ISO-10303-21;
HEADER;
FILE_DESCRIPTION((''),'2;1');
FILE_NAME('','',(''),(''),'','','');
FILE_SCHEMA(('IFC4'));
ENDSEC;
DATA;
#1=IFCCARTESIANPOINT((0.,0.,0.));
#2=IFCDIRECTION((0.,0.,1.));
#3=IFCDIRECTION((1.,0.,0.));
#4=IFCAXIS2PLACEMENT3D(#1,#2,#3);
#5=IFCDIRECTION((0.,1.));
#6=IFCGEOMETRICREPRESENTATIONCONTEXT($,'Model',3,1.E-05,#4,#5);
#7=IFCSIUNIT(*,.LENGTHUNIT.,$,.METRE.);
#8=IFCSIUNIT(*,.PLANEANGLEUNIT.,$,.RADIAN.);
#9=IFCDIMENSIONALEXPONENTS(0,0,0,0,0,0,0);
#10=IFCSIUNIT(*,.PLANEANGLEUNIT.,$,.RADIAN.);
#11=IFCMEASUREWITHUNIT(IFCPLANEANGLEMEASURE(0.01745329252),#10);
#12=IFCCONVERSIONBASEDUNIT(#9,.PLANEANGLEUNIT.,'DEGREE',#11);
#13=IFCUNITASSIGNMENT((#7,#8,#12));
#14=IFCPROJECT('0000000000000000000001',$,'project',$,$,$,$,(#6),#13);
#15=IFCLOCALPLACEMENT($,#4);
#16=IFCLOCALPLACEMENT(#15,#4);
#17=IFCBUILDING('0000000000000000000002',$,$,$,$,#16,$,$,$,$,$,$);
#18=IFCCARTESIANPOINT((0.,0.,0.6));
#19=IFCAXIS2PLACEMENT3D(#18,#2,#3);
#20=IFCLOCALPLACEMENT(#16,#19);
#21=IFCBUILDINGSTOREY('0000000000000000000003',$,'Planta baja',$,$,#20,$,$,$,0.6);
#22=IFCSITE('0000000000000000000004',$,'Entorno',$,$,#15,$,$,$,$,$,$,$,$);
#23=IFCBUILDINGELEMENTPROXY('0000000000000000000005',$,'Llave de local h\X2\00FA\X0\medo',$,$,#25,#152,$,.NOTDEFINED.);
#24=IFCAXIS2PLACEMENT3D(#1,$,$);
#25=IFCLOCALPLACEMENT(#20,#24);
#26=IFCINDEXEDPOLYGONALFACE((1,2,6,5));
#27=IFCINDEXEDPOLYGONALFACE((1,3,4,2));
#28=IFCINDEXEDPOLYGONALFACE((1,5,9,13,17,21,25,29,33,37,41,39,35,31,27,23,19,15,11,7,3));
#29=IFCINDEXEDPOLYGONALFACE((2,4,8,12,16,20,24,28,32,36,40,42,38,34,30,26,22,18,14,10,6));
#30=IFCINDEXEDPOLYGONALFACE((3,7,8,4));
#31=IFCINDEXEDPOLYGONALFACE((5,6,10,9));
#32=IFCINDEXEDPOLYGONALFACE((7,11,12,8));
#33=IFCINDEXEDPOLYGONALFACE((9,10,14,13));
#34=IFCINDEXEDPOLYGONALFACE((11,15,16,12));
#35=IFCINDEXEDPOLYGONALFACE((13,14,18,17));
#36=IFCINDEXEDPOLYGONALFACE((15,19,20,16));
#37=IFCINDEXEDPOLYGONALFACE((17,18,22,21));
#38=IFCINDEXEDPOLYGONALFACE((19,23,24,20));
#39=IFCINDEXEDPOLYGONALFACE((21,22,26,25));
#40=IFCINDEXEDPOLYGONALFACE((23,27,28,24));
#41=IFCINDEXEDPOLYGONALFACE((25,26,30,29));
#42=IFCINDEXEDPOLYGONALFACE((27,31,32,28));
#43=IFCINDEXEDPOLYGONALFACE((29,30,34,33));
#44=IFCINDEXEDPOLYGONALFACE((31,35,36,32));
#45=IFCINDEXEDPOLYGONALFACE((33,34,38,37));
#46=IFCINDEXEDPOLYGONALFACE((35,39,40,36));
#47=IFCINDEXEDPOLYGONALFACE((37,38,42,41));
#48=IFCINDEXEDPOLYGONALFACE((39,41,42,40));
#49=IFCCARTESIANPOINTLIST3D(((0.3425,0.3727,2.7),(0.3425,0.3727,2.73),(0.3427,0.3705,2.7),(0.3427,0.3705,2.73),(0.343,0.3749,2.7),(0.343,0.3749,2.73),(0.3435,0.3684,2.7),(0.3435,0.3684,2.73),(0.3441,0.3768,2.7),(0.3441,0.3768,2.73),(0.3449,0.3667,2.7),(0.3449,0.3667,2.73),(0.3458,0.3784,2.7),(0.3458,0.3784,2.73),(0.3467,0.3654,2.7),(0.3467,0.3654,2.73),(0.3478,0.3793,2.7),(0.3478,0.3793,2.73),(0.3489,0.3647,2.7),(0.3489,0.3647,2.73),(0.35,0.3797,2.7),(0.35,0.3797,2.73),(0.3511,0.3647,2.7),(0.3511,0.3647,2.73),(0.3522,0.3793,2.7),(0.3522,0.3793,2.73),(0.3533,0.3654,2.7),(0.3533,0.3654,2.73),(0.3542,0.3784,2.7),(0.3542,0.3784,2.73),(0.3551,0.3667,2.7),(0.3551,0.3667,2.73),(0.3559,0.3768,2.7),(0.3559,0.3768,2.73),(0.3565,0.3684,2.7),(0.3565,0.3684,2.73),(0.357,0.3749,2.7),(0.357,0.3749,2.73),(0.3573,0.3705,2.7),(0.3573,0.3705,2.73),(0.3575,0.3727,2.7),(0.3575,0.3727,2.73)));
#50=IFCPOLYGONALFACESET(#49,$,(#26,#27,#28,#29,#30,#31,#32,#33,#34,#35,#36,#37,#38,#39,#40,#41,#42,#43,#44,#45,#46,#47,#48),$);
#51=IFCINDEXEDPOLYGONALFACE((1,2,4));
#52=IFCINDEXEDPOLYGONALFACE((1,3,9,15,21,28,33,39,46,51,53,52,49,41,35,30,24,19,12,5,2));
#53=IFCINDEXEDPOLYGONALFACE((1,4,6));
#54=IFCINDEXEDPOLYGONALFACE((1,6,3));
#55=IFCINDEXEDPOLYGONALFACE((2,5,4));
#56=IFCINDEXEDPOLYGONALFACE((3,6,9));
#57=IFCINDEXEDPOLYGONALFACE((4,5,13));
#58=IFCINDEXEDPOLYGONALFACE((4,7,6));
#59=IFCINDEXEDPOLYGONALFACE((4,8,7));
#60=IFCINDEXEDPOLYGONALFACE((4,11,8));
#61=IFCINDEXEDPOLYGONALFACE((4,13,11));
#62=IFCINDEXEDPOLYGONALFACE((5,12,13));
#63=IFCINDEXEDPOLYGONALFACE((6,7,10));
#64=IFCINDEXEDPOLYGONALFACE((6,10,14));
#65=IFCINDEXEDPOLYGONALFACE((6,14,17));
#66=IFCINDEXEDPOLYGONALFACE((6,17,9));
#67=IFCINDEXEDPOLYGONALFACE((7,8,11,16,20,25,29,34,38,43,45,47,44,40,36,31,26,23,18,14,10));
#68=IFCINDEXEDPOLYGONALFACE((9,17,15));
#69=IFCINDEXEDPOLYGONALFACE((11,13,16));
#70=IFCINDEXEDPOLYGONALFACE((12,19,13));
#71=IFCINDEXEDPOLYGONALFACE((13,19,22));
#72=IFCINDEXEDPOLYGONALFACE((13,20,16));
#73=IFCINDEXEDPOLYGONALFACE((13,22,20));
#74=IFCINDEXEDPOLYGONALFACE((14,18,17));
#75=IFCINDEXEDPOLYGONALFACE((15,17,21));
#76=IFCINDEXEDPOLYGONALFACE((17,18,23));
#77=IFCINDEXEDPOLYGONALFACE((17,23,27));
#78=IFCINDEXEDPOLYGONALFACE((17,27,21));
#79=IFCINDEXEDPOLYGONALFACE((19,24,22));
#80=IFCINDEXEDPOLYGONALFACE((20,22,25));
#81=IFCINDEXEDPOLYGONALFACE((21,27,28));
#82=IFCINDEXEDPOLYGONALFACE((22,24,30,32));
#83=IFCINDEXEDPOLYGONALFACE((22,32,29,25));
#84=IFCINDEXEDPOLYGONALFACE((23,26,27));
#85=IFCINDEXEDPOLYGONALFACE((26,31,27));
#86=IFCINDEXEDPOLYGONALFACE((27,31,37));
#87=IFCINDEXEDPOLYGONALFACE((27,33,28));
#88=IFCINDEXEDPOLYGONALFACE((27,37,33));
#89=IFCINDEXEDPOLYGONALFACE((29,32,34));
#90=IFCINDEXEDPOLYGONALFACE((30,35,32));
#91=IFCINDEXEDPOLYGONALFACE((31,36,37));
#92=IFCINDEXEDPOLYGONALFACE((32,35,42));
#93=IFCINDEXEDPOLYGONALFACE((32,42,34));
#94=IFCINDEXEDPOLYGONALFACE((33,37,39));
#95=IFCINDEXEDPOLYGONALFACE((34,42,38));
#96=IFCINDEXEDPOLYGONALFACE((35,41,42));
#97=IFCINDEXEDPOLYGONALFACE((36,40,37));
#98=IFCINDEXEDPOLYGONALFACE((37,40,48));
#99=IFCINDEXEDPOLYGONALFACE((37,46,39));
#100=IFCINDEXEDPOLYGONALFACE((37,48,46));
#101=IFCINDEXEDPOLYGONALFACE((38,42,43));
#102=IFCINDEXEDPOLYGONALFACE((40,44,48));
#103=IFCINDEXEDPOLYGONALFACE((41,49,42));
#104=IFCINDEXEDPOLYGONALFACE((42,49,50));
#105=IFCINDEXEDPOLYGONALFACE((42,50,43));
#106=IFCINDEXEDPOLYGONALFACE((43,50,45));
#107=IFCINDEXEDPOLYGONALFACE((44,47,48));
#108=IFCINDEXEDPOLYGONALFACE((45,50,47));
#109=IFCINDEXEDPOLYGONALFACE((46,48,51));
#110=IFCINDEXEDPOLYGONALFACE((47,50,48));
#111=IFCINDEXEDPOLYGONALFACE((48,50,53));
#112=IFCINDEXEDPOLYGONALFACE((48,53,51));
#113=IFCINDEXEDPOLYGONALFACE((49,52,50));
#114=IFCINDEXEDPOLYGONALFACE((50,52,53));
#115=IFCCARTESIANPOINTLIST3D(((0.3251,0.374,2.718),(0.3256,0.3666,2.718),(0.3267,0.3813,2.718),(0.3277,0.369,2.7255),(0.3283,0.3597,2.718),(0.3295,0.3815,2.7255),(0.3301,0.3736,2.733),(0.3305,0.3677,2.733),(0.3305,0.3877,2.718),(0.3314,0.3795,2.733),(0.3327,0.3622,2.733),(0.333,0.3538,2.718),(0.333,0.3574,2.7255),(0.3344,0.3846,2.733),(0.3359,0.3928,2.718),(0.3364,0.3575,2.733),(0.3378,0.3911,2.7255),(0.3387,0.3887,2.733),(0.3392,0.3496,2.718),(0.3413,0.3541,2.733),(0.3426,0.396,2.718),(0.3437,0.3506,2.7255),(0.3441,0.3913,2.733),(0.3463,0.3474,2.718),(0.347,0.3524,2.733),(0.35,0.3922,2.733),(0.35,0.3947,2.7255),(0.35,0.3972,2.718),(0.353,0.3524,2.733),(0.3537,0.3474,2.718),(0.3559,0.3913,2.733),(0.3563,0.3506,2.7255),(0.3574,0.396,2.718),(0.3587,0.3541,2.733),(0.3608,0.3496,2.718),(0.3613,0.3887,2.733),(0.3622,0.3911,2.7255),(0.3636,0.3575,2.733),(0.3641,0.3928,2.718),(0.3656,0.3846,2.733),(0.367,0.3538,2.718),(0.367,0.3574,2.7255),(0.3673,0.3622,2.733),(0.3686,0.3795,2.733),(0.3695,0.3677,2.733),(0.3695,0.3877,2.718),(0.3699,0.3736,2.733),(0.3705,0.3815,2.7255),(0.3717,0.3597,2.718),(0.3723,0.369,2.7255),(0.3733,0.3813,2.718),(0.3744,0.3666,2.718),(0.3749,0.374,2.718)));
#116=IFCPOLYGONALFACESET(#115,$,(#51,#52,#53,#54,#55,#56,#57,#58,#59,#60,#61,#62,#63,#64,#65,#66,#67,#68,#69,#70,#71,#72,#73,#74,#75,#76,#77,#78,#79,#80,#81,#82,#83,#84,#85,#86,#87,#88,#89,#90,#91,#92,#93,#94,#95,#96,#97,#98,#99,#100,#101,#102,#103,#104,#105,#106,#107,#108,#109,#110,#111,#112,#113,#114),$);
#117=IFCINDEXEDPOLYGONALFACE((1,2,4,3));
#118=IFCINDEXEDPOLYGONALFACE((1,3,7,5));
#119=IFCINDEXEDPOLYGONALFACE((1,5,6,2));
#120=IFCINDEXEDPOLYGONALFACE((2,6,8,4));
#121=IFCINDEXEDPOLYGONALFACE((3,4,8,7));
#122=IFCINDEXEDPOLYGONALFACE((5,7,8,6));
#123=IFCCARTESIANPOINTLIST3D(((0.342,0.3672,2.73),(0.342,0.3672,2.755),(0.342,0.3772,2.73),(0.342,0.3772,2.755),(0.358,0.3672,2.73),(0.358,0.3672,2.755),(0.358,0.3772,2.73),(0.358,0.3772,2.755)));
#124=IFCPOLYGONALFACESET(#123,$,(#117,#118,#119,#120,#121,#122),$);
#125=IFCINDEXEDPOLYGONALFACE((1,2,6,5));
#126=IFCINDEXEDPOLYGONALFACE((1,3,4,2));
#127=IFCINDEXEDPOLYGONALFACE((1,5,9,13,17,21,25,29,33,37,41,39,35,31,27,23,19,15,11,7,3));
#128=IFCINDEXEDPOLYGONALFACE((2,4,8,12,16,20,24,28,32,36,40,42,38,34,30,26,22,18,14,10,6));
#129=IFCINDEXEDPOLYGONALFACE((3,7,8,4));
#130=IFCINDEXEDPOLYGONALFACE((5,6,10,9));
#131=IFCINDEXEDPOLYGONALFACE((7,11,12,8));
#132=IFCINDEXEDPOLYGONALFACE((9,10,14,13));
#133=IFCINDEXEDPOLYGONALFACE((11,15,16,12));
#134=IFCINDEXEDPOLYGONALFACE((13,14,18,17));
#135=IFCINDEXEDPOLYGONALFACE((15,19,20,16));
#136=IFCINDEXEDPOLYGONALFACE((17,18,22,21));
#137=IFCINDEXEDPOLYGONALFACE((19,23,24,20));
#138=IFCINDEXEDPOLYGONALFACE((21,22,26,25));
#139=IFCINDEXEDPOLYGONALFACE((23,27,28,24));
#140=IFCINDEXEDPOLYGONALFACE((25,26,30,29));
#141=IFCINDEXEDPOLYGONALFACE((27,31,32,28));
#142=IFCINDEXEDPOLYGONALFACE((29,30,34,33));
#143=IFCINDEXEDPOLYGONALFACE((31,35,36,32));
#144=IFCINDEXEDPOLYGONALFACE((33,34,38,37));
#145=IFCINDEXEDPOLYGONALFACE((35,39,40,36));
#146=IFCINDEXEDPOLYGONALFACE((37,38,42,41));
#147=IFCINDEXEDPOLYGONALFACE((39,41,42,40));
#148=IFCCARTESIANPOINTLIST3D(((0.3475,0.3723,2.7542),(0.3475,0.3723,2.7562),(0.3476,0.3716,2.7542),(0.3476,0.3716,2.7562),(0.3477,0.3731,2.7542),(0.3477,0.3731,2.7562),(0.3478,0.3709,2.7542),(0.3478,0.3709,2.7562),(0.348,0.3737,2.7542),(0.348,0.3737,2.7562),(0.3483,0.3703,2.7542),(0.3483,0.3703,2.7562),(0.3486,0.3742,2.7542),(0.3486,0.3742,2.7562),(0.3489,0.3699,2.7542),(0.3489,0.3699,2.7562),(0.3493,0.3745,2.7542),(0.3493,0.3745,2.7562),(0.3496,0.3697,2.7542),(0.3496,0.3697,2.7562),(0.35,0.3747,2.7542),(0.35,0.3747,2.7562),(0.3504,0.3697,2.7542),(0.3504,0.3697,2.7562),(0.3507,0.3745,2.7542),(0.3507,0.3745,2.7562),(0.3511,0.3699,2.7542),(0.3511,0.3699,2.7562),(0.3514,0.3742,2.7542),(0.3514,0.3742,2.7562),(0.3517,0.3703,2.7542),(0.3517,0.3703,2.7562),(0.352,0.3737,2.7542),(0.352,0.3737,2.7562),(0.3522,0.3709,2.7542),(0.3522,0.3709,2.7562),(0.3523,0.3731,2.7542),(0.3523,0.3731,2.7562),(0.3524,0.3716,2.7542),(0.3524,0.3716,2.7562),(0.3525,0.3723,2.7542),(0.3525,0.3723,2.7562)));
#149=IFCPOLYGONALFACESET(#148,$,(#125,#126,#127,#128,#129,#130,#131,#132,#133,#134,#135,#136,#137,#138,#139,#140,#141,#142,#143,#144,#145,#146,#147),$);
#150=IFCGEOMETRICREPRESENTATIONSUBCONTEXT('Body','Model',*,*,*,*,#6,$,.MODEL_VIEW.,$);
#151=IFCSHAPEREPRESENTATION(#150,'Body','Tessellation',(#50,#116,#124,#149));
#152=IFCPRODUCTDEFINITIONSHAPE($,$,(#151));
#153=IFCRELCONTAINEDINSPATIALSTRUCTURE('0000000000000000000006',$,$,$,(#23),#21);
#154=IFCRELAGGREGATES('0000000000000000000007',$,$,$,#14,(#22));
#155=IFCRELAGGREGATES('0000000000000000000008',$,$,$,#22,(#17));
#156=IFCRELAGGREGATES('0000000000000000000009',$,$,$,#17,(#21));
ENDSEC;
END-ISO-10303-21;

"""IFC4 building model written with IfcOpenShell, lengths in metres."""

from ifc_helpers import new_model, entity, si_unit, converted_unit, direction, frame, origin_with_axes, place, context, subcontext, project, spatial, polyline, outline, extrude, element, save


model = new_model("IFC4")

# Units and contexts
model_context = context("Model", 3, precision=1e-05, world=origin_with_axes(), true_north=direction((0.0, 1.0)))
body_context = subcontext(model_context, "Body", "Model", "MODEL_VIEW")
ifc_project = project(units=[si_unit("LENGTHUNIT", "METRE"), si_unit("PLANEANGLEUNIT", "RADIAN"), converted_unit("PLANEANGLEUNIT", "DEGREE", entity("IfcPlaneAngleMeasure", 0.01745329252), si_unit("PLANEANGLEUNIT", "RADIAN"), dimensions=[0, 0, 0, 0, 0, 0, 0])], contexts=[model_context])

# Site, building, storey
site_placement = place(None, origin_with_axes())
site = spatial("IfcSite", under=ifc_project, at=site_placement, Name="Entorno")
building_placement = place(site_placement, origin_with_axes())
building = spatial("IfcBuilding", under=site, at=building_placement)
storey_placement = place(building_placement, frame((0.0, 0.0, 0.6), z_axis=(0.0, 0.0, 1.0), x_axis=(1.0, 0.0, 0.0)))
storey = spatial("IfcBuildingStorey", under=building, at=storey_placement, Name="Planta baja", Elevation=0.6)

# Building element proxy
proxy_1_placement = place(storey_placement, frame((0.0, 0.0, -0.6), z_axis=(0.0, 0.0, 1.0), x_axis=(1.0, 0.0, 0.0)))
ifc_direction_1 = entity("IfcDirection", [0.0, 0.0, 1.0])
ifc_direction_2 = entity("IfcDirection", [0.0, 0.0, 1.0])
ifc_direction_3 = entity("IfcDirection", [0.0, 0.0, 1.0])
element("IfcBuildingElementProxy", 1, at=proxy_1_placement, inside=storey, Name="Llave de local húmedo", PredefinedType="NOTDEFINED", context=body_context, shape_type="Brep", body=[
    entity("IfcExtrudedAreaSolidTapered", entity("IfcCircleProfileDef", "AREA", None, entity("IfcAxis2Placement2D", entity("IfcCartesianPoint", [0.0, 0.0]), entity("IfcDirection", [1.0, 0.0])), 0.0075), entity("IfcAxis2Placement3D", entity("IfcCartesianPoint", [0.35, 0.3722, 3.3]), ifc_direction_1, entity("IfcDirection", [0.0, 1.0, 0.0])), ifc_direction_1, 0.03, entity("IfcCircleProfileDef", "AREA", None, entity("IfcAxis2Placement2D", entity("IfcCartesianPoint", [0.0, 0.0]), entity("IfcDirection", [1.0, 0.0])), 0.0075)),
    entity("IfcExtrudedAreaSolidTapered", entity("IfcCircleProfileDef", "AREA", None, entity("IfcAxis2Placement2D", entity("IfcCartesianPoint", [0.0, 0.0]), entity("IfcDirection", [1.0, 0.0])), 0.025), entity("IfcAxis2Placement3D", entity("IfcCartesianPoint", [0.35, 0.3722, 3.318]), ifc_direction_2, entity("IfcDirection", [0.0, 1.0, 0.0])), ifc_direction_2, 0.015, entity("IfcCircleProfileDef", "AREA", None, entity("IfcAxis2Placement2D", entity("IfcCartesianPoint", [0.0, 0.0]), entity("IfcDirection", [1.0, 0.0])), 0.02)),
    extrude(outline(polyline([(0.005, -0.008), (0.005, 0.008), (-0.005, 0.008), (-0.005, -0.008), (0.005, -0.008)])), frame((0.35, 0.3722, 3.33), z_axis=(0.0, 0.0, 1.0), x_axis=(0.0, 1.0, 0.0)), (0.0, 0.0, 1.0), 0.025),
    entity("IfcExtrudedAreaSolidTapered", entity("IfcCircleProfileDef", "AREA", None, entity("IfcAxis2Placement2D", entity("IfcCartesianPoint", [0.0, 0.0]), entity("IfcDirection", [1.0, 0.0])), 0.0025), entity("IfcAxis2Placement3D", entity("IfcCartesianPoint", [0.35, 0.3722, 3.3542]), ifc_direction_3, entity("IfcDirection", [0.0, 1.0, 0.0])), ifc_direction_3, 0.002, entity("IfcCircleProfileDef", "AREA", None, entity("IfcAxis2Placement2D", entity("IfcCartesianPoint", [0.0, 0.0]), entity("IfcDirection", [1.0, 0.0])), 0.0025)),
])

save(model, "model.ifc")
